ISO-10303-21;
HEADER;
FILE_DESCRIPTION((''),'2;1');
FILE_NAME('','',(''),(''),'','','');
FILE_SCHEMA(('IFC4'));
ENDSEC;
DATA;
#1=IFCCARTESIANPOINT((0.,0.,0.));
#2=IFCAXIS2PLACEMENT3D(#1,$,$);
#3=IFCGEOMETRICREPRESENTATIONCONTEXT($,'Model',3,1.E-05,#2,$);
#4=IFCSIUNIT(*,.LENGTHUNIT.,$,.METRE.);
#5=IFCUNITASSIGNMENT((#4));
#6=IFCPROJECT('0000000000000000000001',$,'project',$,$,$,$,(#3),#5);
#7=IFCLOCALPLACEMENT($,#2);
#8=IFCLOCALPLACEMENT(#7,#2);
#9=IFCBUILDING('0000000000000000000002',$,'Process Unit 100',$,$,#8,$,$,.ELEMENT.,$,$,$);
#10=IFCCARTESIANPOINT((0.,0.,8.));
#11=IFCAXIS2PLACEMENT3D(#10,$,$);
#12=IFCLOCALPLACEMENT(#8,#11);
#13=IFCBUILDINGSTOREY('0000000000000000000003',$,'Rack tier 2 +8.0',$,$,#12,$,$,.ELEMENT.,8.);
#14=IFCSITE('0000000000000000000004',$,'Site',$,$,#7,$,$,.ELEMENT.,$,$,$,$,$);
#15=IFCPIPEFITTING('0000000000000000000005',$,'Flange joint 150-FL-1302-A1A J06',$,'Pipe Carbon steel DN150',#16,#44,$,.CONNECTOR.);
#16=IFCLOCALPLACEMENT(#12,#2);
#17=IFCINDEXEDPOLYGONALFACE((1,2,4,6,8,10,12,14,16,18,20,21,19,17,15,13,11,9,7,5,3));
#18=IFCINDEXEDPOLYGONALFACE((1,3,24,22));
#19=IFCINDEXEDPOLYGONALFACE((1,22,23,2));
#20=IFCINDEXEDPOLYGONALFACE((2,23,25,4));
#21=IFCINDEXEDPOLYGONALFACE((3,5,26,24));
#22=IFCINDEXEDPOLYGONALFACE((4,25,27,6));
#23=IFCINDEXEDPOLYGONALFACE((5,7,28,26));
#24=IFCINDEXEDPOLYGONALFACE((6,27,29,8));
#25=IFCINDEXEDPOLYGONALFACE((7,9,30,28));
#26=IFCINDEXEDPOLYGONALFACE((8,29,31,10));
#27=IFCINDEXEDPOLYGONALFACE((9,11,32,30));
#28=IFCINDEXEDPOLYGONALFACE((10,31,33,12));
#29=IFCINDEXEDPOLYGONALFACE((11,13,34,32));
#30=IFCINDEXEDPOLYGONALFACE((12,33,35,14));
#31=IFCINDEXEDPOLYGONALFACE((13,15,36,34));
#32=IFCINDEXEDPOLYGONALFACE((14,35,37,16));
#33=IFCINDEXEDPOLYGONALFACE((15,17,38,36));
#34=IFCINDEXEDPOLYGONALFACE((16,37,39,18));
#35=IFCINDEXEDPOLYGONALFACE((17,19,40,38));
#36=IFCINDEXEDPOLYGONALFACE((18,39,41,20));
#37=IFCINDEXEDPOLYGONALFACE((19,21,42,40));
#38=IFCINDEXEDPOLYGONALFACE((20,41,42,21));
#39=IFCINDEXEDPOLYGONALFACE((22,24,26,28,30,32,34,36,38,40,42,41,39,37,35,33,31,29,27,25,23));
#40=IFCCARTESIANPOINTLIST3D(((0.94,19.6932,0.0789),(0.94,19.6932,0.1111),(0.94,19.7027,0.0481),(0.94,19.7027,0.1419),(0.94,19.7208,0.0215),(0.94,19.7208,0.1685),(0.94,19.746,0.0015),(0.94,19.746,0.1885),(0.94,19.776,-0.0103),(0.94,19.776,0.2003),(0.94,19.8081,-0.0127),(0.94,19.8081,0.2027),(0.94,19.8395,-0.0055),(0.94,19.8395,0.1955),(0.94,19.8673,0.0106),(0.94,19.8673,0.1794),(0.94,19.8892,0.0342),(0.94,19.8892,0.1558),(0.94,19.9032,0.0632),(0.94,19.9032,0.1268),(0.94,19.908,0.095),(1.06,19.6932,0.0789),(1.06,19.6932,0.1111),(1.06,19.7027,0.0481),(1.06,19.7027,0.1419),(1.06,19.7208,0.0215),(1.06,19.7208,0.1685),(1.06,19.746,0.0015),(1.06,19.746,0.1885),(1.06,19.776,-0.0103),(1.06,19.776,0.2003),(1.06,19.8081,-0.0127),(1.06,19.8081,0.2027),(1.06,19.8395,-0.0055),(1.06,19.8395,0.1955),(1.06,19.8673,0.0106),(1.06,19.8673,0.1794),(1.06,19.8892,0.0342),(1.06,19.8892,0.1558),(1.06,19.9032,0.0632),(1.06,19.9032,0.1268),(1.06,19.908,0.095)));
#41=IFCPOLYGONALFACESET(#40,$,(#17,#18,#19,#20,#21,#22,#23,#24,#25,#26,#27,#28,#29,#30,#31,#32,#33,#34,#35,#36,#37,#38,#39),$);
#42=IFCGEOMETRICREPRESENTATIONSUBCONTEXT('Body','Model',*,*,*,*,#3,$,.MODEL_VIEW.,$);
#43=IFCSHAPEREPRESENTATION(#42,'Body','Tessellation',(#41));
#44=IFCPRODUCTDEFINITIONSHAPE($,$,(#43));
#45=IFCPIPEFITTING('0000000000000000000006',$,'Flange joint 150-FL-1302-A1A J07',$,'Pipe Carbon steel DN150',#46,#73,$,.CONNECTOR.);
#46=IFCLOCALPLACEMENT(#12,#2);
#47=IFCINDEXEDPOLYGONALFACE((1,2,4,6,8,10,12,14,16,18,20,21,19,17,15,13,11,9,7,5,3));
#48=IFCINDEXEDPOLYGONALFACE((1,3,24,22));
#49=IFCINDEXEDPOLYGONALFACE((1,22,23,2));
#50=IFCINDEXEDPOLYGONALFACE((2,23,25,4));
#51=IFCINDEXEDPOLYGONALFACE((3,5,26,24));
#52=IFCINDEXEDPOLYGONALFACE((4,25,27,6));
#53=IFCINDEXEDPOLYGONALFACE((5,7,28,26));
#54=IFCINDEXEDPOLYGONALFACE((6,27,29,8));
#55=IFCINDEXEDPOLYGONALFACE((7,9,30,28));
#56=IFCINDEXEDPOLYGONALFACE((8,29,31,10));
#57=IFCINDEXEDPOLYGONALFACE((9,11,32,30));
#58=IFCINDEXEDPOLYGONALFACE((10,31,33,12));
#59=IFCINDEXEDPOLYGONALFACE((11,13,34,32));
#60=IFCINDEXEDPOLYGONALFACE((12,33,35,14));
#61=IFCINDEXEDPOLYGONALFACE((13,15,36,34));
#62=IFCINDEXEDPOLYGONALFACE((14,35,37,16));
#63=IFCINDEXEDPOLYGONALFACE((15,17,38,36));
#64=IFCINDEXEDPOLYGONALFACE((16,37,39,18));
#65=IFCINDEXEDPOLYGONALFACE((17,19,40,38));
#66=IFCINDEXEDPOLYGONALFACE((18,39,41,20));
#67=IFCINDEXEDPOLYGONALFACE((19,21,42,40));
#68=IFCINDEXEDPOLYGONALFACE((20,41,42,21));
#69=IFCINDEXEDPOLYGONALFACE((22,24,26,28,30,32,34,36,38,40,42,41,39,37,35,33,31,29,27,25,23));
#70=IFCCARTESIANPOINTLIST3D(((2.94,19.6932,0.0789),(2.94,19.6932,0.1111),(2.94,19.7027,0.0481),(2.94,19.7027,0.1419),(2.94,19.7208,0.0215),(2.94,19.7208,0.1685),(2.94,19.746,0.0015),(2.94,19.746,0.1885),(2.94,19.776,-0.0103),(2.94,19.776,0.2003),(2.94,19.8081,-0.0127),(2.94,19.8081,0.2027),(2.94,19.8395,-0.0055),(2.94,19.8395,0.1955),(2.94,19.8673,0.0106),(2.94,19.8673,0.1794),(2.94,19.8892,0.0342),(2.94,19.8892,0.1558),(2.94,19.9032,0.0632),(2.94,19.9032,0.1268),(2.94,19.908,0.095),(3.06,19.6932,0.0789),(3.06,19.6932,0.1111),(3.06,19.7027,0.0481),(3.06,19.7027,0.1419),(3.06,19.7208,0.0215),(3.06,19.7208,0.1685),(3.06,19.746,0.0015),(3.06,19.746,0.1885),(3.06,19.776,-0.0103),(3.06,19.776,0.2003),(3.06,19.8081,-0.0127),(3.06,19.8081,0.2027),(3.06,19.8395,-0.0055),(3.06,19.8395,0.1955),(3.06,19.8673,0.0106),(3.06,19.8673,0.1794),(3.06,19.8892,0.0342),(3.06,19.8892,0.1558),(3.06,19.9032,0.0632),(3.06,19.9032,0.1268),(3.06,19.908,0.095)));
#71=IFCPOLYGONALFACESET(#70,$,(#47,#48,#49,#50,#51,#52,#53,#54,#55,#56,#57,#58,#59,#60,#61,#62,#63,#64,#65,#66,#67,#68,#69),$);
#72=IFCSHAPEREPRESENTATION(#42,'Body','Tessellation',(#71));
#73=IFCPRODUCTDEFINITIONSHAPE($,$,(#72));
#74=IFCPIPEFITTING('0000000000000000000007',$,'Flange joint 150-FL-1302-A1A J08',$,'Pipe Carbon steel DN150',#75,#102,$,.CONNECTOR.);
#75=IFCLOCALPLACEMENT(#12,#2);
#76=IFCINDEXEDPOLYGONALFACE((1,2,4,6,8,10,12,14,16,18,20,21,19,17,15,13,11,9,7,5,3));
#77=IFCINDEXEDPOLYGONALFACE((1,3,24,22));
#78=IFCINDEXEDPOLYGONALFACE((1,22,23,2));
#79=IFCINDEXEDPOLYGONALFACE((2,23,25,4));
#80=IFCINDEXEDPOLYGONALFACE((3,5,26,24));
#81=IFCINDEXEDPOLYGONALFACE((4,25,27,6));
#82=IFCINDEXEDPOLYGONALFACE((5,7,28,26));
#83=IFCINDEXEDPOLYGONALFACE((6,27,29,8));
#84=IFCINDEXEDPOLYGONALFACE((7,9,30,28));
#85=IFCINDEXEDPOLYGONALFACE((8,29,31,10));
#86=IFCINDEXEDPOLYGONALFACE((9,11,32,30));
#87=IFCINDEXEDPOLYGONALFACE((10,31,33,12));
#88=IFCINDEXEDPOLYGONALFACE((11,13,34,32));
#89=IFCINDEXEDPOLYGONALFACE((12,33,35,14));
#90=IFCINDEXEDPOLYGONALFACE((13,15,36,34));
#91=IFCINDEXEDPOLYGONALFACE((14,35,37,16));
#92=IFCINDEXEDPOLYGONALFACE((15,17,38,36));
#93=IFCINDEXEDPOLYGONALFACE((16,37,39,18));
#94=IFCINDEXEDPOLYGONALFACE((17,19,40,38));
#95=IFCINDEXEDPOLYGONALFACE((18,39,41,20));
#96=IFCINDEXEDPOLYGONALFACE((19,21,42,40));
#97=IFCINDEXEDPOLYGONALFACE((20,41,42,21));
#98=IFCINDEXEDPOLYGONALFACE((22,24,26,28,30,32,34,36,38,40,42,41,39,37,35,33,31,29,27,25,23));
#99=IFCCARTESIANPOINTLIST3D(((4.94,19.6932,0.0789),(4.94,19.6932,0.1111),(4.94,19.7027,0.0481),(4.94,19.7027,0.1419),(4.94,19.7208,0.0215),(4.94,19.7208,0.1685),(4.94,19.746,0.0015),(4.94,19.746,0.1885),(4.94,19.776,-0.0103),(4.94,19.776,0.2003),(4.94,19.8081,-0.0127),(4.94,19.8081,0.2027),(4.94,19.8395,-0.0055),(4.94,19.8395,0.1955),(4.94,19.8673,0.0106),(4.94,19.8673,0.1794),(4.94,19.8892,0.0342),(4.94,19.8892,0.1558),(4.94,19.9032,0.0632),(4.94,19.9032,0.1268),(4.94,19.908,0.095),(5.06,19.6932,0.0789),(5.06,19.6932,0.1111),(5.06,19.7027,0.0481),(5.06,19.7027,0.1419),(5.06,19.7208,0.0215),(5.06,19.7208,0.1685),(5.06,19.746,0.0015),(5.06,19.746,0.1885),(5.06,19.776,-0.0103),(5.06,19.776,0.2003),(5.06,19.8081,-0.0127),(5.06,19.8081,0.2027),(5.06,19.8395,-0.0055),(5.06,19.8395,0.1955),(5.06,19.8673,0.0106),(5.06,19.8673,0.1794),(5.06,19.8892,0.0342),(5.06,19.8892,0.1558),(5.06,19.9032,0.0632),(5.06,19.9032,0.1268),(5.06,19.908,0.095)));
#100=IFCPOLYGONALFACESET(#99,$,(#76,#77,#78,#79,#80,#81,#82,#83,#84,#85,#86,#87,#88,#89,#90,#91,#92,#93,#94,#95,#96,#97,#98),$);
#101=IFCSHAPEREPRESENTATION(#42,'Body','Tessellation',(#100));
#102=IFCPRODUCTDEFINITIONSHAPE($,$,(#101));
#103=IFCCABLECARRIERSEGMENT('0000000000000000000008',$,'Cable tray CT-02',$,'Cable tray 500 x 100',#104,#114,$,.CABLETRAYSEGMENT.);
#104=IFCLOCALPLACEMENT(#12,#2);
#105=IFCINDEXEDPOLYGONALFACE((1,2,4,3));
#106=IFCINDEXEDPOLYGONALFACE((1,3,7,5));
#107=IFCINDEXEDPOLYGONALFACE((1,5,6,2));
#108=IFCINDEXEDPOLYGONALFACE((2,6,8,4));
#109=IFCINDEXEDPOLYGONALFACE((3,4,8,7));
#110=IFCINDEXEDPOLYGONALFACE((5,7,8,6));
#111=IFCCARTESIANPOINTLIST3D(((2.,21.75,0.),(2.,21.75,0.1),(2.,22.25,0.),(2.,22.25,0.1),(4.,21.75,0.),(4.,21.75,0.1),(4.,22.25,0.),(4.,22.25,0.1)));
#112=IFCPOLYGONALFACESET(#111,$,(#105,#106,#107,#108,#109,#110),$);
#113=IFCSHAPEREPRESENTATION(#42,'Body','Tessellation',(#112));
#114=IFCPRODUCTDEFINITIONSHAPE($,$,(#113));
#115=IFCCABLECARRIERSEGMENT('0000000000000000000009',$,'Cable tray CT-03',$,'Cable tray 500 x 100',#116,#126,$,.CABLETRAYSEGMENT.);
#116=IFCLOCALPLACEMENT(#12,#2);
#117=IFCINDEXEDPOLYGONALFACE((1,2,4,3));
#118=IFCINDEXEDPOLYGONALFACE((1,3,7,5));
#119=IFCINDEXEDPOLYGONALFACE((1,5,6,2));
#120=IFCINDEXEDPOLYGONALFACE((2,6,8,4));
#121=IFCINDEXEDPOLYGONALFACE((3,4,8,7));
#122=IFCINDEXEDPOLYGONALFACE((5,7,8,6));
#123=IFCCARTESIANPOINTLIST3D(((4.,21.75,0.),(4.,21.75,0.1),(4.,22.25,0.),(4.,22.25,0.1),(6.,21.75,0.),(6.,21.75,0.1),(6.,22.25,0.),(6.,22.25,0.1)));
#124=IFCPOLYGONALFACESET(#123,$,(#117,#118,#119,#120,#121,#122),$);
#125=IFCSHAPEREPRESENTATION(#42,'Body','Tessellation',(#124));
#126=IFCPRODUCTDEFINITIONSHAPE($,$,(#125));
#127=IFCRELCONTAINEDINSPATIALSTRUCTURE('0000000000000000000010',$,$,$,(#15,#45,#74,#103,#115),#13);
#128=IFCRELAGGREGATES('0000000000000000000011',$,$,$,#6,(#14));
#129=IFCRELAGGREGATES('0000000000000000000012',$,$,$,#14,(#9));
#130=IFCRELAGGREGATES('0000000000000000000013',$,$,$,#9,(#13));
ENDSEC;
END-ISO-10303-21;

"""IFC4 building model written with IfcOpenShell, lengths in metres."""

from ifc_helpers import new_model, si_unit, frame, origin, place, context, subcontext, project, spatial, rectangle, circle, extrude, element, save


model = new_model("IFC4")

# Units and contexts
model_context = context("Model", 3, precision=1e-05, world=origin())
body_context = subcontext(model_context, "Body", "Model", "MODEL_VIEW")
ifc_project = project(units=[si_unit("LENGTHUNIT", "METRE")], contexts=[model_context])

# Site, building, storey
site_placement = place(None, origin())
site = spatial("IfcSite", under=ifc_project, at=site_placement, Name="Site", CompositionType="ELEMENT")
building_placement = place(site_placement, origin())
building = spatial("IfcBuilding", under=site, at=building_placement, Name="Process Unit 100", CompositionType="ELEMENT")
storey_placement = place(building_placement, frame((0.0, 0.0, 8.0)))
storey = spatial("IfcBuildingStorey", under=building, at=storey_placement, Name="Rack tier 2 +8.0", CompositionType="ELEMENT", Elevation=8.0)

# Pipe fittings
for number, where, z_axis, x_axis, name in (
    (1, (0.94, 19.8, 0.095), (1.0, 0.0, 0.0), (0.0, 1.0, 0.0), "Flange joint 150-FL-1302-A1A J06"),
    (2, (2.94, 19.8, 0.095), (1.0, 0.0, 0.0), (0.0, 1.0, 0.0), "Flange joint 150-FL-1302-A1A J07"),
    (3, (4.94, 19.8, 0.095), (1.0, 0.0, 0.0), (0.0, 1.0, 0.0), "Flange joint 150-FL-1302-A1A J08"),
):
    element("IfcPipeFitting", number, at=place(storey_placement, frame(where, z_axis=z_axis, x_axis=x_axis)), inside=storey, Name=name, ObjectType="Pipe Carbon steel DN150", PredefinedType="CONNECTOR", context=body_context, shape_type="SweptSolid", body=[
        extrude(circle(Radius=0.108), origin(), (0.0, 0.0, 1.0), 0.12),
    ])

# Cable carrier segments
for number, where, z_axis, x_axis, name in (
    (4, (2.0, 22.0, 0.05), (1.0, 0.0, 0.0), (0.0, 1.0, 0.0), "Cable tray CT-02"),
    (5, (4.0, 22.0, 0.05), (1.0, 0.0, 0.0), (0.0, 1.0, 0.0), "Cable tray CT-03"),
):
    element("IfcCableCarrierSegment", number, at=place(storey_placement, frame(where, z_axis=z_axis, x_axis=x_axis)), inside=storey, Name=name, ObjectType="Cable tray 500 x 100", PredefinedType="CABLETRAYSEGMENT", context=body_context, shape_type="SweptSolid", body=[
        extrude(rectangle(XDim=0.5, YDim=0.1), origin(), (0.0, 0.0, 1.0), 2.0),
    ])

save(model, "model.ifc")
